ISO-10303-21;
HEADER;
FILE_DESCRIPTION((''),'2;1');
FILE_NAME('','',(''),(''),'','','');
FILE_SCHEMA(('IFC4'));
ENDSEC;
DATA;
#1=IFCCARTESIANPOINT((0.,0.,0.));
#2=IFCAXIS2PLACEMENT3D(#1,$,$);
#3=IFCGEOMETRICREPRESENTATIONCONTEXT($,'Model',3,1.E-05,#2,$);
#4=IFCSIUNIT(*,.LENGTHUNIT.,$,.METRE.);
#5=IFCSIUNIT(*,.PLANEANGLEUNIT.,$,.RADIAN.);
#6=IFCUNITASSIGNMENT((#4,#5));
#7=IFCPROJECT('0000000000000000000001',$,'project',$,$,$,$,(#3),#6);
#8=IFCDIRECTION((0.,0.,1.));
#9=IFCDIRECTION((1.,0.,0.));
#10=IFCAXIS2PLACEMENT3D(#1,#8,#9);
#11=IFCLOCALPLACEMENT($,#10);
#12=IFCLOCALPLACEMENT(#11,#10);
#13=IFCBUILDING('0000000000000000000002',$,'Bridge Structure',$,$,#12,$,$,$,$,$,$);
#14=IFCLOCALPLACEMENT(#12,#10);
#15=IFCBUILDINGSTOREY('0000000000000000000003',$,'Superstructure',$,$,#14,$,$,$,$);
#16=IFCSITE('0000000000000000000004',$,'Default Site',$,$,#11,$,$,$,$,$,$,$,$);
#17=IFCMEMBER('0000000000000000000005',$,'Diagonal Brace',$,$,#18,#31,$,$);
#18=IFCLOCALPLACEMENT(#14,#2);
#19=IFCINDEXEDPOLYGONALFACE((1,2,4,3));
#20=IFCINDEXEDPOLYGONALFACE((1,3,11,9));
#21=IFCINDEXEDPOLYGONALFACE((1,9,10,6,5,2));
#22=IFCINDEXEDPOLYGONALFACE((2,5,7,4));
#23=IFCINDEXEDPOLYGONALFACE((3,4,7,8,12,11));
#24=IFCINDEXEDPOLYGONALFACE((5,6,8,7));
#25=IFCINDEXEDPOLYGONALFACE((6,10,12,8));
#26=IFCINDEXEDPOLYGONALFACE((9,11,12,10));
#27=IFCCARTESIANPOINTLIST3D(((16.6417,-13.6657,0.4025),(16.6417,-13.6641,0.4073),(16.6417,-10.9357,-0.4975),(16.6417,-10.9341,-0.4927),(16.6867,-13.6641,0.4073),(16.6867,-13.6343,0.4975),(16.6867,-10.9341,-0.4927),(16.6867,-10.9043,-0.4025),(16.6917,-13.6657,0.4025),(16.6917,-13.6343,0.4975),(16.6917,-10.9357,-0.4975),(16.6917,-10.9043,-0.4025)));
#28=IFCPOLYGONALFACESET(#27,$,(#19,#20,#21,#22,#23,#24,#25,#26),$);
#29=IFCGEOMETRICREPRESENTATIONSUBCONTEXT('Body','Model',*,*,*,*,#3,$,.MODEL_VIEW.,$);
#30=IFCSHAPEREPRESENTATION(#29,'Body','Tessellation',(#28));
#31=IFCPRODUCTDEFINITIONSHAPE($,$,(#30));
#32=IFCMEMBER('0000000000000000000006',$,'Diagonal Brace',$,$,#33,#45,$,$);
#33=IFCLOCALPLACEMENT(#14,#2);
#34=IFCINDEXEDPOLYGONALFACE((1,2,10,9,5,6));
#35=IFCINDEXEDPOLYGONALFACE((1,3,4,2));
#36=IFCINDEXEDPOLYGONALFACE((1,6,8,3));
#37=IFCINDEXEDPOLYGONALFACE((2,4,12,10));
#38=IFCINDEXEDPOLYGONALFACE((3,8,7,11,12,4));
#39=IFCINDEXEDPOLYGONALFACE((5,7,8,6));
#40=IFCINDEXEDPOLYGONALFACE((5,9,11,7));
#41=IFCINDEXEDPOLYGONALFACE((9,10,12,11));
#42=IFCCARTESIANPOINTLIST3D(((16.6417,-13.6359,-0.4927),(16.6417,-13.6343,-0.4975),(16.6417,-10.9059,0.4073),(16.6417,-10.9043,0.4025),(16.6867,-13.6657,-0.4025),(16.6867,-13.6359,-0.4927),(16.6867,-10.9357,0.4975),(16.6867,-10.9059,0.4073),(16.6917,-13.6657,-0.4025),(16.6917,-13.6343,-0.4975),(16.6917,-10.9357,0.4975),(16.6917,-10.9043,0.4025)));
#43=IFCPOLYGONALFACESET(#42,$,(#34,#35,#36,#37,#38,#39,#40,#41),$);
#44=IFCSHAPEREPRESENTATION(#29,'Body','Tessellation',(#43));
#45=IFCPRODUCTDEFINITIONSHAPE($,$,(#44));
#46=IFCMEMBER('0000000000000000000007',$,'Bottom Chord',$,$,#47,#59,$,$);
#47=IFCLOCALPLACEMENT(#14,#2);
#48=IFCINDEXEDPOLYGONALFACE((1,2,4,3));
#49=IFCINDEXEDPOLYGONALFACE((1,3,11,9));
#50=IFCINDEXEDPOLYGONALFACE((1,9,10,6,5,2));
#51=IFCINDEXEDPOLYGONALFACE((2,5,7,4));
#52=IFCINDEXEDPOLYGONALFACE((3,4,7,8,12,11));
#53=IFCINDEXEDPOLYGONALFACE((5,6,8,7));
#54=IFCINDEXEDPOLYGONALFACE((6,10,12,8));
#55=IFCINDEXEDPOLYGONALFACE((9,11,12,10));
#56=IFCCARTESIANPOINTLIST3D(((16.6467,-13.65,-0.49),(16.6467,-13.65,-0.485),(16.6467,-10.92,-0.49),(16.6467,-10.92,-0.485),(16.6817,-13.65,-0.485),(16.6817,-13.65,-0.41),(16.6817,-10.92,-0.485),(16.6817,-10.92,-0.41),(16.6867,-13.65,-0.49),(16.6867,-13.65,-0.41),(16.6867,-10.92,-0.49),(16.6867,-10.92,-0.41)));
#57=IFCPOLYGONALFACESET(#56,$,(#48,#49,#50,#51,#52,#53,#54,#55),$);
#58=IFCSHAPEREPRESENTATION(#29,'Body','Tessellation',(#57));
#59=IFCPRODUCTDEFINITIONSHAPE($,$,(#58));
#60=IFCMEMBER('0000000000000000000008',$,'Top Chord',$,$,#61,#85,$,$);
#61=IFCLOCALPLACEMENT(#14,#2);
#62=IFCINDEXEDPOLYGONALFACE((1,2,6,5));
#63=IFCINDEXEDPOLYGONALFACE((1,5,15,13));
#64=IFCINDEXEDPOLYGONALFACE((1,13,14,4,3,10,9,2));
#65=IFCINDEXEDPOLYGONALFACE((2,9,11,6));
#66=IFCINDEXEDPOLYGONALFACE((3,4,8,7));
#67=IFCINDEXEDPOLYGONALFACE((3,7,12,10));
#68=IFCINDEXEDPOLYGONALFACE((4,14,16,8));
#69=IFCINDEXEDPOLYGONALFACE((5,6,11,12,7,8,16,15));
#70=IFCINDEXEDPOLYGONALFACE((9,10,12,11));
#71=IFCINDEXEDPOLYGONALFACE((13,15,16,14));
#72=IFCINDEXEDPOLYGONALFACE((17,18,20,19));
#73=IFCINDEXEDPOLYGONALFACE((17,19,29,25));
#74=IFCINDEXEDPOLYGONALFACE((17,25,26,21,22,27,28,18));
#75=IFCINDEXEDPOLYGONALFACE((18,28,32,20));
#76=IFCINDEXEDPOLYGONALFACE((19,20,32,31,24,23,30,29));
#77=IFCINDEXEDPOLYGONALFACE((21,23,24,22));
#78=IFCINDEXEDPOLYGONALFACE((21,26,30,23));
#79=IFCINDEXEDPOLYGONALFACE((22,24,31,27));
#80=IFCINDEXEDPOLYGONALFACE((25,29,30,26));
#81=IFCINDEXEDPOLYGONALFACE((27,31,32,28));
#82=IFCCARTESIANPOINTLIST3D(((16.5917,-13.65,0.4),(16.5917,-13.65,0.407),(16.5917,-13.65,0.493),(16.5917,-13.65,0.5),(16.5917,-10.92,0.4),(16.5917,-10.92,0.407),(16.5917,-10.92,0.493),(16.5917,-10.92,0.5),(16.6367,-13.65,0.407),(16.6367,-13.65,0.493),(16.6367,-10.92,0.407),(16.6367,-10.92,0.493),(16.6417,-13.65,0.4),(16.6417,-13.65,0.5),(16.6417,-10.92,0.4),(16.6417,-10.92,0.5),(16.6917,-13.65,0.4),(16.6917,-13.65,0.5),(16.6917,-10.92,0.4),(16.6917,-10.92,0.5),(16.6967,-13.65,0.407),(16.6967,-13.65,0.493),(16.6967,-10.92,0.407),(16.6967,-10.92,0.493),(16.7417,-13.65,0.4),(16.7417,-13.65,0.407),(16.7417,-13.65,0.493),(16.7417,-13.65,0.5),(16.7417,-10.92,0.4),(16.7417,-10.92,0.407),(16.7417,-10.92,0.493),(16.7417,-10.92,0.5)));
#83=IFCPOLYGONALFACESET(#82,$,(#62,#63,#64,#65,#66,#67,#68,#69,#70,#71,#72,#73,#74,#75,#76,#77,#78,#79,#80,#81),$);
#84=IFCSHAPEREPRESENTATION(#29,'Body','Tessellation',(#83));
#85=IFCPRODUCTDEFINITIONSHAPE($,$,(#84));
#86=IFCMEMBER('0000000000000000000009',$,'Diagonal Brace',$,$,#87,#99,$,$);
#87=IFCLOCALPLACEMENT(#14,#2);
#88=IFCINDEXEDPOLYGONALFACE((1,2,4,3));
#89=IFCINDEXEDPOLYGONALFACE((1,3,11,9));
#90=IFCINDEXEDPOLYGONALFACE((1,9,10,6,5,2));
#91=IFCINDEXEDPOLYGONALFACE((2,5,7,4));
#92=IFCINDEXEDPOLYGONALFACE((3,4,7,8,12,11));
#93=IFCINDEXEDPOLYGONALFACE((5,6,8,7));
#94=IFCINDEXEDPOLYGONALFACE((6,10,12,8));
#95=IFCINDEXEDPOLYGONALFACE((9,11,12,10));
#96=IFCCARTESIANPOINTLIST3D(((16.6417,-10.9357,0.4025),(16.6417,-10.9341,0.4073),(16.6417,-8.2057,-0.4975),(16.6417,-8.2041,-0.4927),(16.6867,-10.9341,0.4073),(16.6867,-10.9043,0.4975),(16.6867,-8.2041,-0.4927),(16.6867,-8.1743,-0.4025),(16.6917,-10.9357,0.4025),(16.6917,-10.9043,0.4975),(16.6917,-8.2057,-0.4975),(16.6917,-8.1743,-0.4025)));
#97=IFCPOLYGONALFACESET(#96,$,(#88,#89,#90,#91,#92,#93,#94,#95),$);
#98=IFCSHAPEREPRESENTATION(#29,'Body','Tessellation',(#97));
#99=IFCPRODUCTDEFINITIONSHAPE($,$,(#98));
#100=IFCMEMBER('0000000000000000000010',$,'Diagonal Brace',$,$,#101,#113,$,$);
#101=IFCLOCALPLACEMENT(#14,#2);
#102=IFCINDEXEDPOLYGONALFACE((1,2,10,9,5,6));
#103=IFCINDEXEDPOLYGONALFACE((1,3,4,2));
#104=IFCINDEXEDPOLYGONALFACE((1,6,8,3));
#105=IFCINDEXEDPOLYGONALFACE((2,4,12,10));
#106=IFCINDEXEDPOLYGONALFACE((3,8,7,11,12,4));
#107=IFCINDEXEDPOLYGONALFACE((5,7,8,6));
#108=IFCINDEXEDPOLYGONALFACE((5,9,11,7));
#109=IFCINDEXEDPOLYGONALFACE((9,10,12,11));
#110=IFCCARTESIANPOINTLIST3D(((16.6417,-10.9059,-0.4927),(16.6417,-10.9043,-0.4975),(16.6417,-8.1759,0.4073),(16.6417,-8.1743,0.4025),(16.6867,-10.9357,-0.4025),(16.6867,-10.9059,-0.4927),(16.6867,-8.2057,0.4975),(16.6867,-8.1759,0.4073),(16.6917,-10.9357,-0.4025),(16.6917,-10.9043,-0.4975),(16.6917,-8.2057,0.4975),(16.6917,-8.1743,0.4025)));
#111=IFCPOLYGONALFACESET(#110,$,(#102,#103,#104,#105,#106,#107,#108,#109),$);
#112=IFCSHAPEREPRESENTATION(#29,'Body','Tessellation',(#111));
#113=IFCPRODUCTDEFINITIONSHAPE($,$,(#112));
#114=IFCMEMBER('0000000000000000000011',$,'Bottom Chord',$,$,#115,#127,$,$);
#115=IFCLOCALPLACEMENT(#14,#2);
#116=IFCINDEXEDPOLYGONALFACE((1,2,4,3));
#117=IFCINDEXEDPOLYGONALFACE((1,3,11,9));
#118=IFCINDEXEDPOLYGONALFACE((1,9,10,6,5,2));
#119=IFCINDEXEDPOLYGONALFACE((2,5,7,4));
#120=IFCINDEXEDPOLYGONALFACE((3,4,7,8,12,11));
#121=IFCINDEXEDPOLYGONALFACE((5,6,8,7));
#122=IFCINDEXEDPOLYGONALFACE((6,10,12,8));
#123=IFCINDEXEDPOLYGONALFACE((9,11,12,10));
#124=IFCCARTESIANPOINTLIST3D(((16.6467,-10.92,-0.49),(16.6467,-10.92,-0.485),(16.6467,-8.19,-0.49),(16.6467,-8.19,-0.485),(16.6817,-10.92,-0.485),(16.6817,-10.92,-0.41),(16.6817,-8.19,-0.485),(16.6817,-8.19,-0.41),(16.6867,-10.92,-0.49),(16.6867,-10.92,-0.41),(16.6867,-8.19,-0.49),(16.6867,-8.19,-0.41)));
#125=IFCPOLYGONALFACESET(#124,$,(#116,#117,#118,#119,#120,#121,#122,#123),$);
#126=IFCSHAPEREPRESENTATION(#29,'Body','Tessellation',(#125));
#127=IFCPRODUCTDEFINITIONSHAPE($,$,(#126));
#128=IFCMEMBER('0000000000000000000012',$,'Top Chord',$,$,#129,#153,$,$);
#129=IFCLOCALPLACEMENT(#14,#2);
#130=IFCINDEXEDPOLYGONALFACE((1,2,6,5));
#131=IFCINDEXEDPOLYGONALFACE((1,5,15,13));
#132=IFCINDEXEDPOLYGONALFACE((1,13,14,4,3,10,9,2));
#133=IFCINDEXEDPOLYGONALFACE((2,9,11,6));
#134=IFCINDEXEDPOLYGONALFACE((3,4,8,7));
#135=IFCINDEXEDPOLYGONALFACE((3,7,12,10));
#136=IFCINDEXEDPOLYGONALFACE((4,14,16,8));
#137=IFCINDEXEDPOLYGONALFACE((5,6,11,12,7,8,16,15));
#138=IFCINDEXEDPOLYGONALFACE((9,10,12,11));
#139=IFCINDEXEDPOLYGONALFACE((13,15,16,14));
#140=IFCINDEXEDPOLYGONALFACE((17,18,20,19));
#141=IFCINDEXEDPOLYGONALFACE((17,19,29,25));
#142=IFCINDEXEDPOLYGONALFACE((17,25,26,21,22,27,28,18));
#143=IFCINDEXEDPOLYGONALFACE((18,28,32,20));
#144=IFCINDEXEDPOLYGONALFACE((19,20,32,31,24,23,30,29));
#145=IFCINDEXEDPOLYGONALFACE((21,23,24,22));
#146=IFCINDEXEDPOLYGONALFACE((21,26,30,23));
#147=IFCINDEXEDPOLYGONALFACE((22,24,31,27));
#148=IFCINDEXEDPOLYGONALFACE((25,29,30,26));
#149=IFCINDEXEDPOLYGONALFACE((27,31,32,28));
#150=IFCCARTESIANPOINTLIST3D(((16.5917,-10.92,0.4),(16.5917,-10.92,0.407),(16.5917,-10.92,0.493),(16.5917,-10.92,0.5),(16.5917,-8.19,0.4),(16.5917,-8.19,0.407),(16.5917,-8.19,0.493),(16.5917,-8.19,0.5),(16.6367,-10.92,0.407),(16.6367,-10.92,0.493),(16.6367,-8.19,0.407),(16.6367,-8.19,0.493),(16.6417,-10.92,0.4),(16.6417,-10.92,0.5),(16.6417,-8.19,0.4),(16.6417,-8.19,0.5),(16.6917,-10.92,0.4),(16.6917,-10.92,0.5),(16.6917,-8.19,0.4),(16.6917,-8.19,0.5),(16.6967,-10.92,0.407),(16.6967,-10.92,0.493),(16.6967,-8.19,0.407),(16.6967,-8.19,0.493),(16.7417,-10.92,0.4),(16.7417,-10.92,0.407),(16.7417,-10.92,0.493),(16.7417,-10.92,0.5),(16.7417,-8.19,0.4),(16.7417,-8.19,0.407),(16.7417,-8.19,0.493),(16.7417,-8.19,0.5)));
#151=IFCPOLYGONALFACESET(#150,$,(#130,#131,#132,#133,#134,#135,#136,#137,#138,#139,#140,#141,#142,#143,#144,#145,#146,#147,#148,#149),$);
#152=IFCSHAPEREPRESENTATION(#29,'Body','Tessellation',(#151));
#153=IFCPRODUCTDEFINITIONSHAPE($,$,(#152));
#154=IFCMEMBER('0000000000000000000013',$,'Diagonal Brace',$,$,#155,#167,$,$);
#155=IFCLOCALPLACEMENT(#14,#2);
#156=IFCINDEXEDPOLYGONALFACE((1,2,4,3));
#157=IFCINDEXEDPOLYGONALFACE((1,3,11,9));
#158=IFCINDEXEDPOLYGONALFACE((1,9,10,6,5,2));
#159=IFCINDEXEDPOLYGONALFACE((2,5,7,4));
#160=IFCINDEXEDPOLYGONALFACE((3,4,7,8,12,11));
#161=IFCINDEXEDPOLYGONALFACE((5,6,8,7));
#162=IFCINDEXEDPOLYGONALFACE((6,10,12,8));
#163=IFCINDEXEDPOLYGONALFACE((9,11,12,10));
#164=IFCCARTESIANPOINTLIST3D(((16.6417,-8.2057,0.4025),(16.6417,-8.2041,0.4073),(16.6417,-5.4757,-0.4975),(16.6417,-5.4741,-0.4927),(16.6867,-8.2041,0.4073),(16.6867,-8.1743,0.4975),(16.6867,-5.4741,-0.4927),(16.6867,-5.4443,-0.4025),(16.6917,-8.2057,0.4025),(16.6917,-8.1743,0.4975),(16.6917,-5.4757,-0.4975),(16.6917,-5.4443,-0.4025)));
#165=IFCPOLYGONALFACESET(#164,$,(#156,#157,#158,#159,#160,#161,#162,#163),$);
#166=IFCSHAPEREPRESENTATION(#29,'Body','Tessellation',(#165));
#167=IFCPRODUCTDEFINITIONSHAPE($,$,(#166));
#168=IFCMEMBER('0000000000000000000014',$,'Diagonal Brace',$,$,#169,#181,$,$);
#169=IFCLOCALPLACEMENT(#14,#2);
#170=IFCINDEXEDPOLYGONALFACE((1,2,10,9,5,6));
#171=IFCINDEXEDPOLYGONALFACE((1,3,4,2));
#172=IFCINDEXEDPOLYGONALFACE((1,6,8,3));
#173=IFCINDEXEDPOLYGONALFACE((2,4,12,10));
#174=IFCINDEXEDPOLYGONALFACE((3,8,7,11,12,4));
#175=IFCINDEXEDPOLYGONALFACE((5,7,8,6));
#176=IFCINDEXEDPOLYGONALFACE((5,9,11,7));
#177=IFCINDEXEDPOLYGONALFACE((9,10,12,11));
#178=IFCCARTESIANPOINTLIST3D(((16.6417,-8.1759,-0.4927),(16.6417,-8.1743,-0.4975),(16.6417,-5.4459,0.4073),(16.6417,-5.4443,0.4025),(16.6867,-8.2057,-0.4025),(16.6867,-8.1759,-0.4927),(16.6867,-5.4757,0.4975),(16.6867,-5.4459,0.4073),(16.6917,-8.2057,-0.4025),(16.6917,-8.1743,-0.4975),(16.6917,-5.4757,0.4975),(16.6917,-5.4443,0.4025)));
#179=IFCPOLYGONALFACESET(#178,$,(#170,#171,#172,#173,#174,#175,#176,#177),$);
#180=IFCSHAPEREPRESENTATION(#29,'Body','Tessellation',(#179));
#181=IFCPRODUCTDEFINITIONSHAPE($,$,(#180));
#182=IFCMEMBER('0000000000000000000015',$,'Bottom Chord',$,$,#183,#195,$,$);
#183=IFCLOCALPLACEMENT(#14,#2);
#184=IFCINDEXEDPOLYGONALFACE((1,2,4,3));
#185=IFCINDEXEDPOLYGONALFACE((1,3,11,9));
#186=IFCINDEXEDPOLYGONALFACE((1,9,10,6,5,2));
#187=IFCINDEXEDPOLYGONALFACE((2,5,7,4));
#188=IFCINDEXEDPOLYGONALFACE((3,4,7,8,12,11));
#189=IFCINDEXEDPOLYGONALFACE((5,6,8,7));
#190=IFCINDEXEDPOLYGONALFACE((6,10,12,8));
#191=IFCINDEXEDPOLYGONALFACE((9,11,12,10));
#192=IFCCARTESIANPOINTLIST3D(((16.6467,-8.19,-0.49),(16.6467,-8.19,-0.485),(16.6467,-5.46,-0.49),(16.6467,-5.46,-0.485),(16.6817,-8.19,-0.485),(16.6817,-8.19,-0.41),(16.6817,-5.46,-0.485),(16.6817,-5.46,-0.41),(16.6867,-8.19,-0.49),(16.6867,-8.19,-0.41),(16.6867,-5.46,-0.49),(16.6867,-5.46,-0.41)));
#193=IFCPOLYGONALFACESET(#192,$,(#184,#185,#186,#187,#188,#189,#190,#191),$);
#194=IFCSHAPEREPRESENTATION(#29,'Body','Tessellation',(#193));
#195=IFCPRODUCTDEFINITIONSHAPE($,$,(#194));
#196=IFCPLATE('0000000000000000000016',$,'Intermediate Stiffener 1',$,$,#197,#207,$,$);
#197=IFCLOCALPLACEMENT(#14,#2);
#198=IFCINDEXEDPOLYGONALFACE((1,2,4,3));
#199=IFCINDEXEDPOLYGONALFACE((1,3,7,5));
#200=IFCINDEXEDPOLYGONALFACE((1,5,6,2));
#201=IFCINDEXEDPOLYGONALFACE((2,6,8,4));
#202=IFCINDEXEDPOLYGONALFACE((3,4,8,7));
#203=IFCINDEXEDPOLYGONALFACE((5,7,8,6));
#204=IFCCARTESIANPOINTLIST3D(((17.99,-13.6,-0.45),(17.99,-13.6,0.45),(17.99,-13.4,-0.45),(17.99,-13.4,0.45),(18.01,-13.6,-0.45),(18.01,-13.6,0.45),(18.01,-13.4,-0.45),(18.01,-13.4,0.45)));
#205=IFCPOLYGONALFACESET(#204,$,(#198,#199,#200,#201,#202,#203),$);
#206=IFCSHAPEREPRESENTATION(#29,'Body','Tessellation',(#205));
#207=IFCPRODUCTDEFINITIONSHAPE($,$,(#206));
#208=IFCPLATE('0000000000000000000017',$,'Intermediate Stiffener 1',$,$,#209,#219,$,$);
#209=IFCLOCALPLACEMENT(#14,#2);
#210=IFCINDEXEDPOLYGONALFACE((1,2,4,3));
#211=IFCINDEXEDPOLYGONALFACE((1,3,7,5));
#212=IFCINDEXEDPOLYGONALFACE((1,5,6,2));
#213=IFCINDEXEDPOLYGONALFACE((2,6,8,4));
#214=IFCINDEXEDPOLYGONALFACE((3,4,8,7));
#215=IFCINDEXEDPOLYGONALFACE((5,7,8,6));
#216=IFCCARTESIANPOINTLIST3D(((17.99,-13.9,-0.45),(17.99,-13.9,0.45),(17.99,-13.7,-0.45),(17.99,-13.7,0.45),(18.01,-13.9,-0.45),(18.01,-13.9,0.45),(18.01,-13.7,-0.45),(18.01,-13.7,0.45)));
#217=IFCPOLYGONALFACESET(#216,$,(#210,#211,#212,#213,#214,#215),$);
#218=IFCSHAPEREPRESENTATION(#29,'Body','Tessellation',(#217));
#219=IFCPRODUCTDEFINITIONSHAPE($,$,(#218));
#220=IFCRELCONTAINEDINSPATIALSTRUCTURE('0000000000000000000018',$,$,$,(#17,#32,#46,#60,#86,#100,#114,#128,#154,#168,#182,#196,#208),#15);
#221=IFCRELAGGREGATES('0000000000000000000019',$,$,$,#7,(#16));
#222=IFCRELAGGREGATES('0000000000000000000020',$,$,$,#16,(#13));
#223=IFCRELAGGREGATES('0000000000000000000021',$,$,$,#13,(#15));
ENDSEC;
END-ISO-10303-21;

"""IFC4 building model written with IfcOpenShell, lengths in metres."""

from ifc_helpers import new_model, si_unit, frame, origin, origin_with_axes, origin_2d_with_axis, place, context, subcontext, project, spatial, polyline, rectangle, l_section, outline, composite_profile, extrude, element, save


model = new_model("IFC4")

# Units and contexts
model_context = context("Model", 3, precision=1e-05, world=origin())
body_context = subcontext(model_context, "Body", "Model", "MODEL_VIEW")
ifc_project = project(units=[si_unit("LENGTHUNIT", "METRE"), si_unit("PLANEANGLEUNIT", "RADIAN")], contexts=[model_context])

# Site, building, storey
site_placement = place(None, origin_with_axes())
site = spatial("IfcSite", under=ifc_project, at=site_placement, Name="Default Site")
building_placement = place(site_placement, origin_with_axes())
building = spatial("IfcBuilding", under=site, at=building_placement, Name="Bridge Structure")
storey_placement = place(building_placement, origin_with_axes())
storey = spatial("IfcBuildingStorey", under=building, at=storey_placement, Name="Superstructure")

# Members
for number, where, z_axis, x_axis, name in (
    (1, (16.6667, -13.65, 0.45), (0.0, 0.949722, -0.313095), (-1.0, 0.0, 0.0), "Diagonal Brace"),
    (2, (16.6667, -13.65, -0.45), (0.0, 0.949722, 0.313095), (-1.0, 0.0, 0.0), "Diagonal Brace"),
):
    element("IfcMember", number, at=place(storey_placement, frame(where, z_axis=z_axis, x_axis=x_axis)), inside=storey, Name=name, context=body_context, shape_type="SweptSolid", body=[
        extrude(l_section(Depth=0.1, Width=0.05, Thickness=0.005, at=origin_2d_with_axis()), origin_with_axes(), (0.0, 0.0, 1.0), 2.8745),
    ])
member_1_placement = place(storey_placement, frame((16.6667, -13.65, -0.45), z_axis=(0.0, 1.0, 0.0), x_axis=(-1.0, 0.0, 0.0)))
element("IfcMember", 3, at=member_1_placement, inside=storey, Name="Bottom Chord", context=body_context, shape_type="SweptSolid", body=[
    extrude(l_section(Depth=0.08, Width=0.04, Thickness=0.005, at=origin_2d_with_axis()), origin_with_axes(), (0.0, 0.0, 1.0), 2.73),
])
member_2_placement = place(storey_placement, frame((16.6667, -13.65, 0.45), z_axis=(0.0, 1.0, 0.0), x_axis=(-1.0, 0.0, 0.0)))
element("IfcMember", 4, at=member_2_placement, inside=storey, Name="Top Chord", context=body_context, shape_type="SweptSolid", body=[
    extrude(composite_profile([outline(polyline([(-0.025, -0.05), (-0.025, 0.05), (-0.075, 0.05), (-0.075, 0.043), (-0.03, 0.043), (-0.03, -0.043), (-0.075, -0.043), (-0.075, -0.05), (-0.025, -0.05)])), outline(polyline([(0.025, -0.05), (0.075, -0.05), (0.075, -0.043), (0.03, -0.043), (0.03, 0.043), (0.075, 0.043), (0.075, 0.05), (0.025, 0.05), (0.025, -0.05)]))]), origin_with_axes(), (0.0, 0.0, 1.0), 2.73),
])
for number, where, z_axis, x_axis, name in (
    (5, (16.6667, -10.92, 0.45), (0.0, 0.949722, -0.313095), (-1.0, 0.0, 0.0), "Diagonal Brace"),
    (6, (16.6667, -10.92, -0.45), (0.0, 0.949722, 0.313095), (-1.0, 0.0, 0.0), "Diagonal Brace"),
):
    element("IfcMember", number, at=place(storey_placement, frame(where, z_axis=z_axis, x_axis=x_axis)), inside=storey, Name=name, context=body_context, shape_type="SweptSolid", body=[
        extrude(l_section(Depth=0.1, Width=0.05, Thickness=0.005, at=origin_2d_with_axis()), origin_with_axes(), (0.0, 0.0, 1.0), 2.8745),
    ])
member_3_placement = place(storey_placement, frame((16.6667, -10.92, -0.45), z_axis=(0.0, 1.0, 0.0), x_axis=(-1.0, 0.0, 0.0)))
element("IfcMember", 7, at=member_3_placement, inside=storey, Name="Bottom Chord", context=body_context, shape_type="SweptSolid", body=[
    extrude(l_section(Depth=0.08, Width=0.04, Thickness=0.005, at=origin_2d_with_axis()), origin_with_axes(), (0.0, 0.0, 1.0), 2.73),
])
member_4_placement = place(storey_placement, frame((16.6667, -10.92, 0.45), z_axis=(0.0, 1.0, 0.0), x_axis=(-1.0, 0.0, 0.0)))
element("IfcMember", 8, at=member_4_placement, inside=storey, Name="Top Chord", context=body_context, shape_type="SweptSolid", body=[
    extrude(composite_profile([outline(polyline([(-0.025, -0.05), (-0.025, 0.05), (-0.075, 0.05), (-0.075, 0.043), (-0.03, 0.043), (-0.03, -0.043), (-0.075, -0.043), (-0.075, -0.05), (-0.025, -0.05)])), outline(polyline([(0.025, -0.05), (0.075, -0.05), (0.075, -0.043), (0.03, -0.043), (0.03, 0.043), (0.075, 0.043), (0.075, 0.05), (0.025, 0.05), (0.025, -0.05)]))]), origin_with_axes(), (0.0, 0.0, 1.0), 2.73),
])
for number, where, z_axis, x_axis, name in (
    (9, (16.6667, -8.19, 0.45), (0.0, 0.949722, -0.313095), (-1.0, 0.0, 0.0), "Diagonal Brace"),
    (10, (16.6667, -8.19, -0.45), (0.0, 0.949722, 0.313095), (-1.0, 0.0, 0.0), "Diagonal Brace"),
):
    element("IfcMember", number, at=place(storey_placement, frame(where, z_axis=z_axis, x_axis=x_axis)), inside=storey, Name=name, context=body_context, shape_type="SweptSolid", body=[
        extrude(l_section(Depth=0.1, Width=0.05, Thickness=0.005, at=origin_2d_with_axis()), origin_with_axes(), (0.0, 0.0, 1.0), 2.8745),
    ])
member_5_placement = place(storey_placement, frame((16.6667, -8.19, -0.45), z_axis=(0.0, 1.0, 0.0), x_axis=(-1.0, 0.0, 0.0)))
element("IfcMember", 11, at=member_5_placement, inside=storey, Name="Bottom Chord", context=body_context, shape_type="SweptSolid", body=[
    extrude(l_section(Depth=0.08, Width=0.04, Thickness=0.005, at=origin_2d_with_axis()), origin_with_axes(), (0.0, 0.0, 1.0), 2.73),
])

# Plates
for number, where, z_axis, x_axis, name in (
    (12, (18.0, -13.5, -0.45), (0.0, 0.0, 1.0), (1.0, 0.0, 0.0), "Intermediate Stiffener 1"),
    (13, (18.0, -13.8, -0.45), (0.0, 0.0, 1.0), (1.0, 0.0, 0.0), "Intermediate Stiffener 1"),
):
    element("IfcPlate", number, at=place(storey_placement, frame(where, z_axis=z_axis, x_axis=x_axis)), inside=storey, Name=name, context=body_context, shape_type="SweptSolid", body=[
        extrude(rectangle(XDim=0.02, YDim=0.2, at=origin_2d_with_axis()), origin_with_axes(), (0.0, 0.0, 1.0), 0.9),
    ])

save(model, "model.ifc")
